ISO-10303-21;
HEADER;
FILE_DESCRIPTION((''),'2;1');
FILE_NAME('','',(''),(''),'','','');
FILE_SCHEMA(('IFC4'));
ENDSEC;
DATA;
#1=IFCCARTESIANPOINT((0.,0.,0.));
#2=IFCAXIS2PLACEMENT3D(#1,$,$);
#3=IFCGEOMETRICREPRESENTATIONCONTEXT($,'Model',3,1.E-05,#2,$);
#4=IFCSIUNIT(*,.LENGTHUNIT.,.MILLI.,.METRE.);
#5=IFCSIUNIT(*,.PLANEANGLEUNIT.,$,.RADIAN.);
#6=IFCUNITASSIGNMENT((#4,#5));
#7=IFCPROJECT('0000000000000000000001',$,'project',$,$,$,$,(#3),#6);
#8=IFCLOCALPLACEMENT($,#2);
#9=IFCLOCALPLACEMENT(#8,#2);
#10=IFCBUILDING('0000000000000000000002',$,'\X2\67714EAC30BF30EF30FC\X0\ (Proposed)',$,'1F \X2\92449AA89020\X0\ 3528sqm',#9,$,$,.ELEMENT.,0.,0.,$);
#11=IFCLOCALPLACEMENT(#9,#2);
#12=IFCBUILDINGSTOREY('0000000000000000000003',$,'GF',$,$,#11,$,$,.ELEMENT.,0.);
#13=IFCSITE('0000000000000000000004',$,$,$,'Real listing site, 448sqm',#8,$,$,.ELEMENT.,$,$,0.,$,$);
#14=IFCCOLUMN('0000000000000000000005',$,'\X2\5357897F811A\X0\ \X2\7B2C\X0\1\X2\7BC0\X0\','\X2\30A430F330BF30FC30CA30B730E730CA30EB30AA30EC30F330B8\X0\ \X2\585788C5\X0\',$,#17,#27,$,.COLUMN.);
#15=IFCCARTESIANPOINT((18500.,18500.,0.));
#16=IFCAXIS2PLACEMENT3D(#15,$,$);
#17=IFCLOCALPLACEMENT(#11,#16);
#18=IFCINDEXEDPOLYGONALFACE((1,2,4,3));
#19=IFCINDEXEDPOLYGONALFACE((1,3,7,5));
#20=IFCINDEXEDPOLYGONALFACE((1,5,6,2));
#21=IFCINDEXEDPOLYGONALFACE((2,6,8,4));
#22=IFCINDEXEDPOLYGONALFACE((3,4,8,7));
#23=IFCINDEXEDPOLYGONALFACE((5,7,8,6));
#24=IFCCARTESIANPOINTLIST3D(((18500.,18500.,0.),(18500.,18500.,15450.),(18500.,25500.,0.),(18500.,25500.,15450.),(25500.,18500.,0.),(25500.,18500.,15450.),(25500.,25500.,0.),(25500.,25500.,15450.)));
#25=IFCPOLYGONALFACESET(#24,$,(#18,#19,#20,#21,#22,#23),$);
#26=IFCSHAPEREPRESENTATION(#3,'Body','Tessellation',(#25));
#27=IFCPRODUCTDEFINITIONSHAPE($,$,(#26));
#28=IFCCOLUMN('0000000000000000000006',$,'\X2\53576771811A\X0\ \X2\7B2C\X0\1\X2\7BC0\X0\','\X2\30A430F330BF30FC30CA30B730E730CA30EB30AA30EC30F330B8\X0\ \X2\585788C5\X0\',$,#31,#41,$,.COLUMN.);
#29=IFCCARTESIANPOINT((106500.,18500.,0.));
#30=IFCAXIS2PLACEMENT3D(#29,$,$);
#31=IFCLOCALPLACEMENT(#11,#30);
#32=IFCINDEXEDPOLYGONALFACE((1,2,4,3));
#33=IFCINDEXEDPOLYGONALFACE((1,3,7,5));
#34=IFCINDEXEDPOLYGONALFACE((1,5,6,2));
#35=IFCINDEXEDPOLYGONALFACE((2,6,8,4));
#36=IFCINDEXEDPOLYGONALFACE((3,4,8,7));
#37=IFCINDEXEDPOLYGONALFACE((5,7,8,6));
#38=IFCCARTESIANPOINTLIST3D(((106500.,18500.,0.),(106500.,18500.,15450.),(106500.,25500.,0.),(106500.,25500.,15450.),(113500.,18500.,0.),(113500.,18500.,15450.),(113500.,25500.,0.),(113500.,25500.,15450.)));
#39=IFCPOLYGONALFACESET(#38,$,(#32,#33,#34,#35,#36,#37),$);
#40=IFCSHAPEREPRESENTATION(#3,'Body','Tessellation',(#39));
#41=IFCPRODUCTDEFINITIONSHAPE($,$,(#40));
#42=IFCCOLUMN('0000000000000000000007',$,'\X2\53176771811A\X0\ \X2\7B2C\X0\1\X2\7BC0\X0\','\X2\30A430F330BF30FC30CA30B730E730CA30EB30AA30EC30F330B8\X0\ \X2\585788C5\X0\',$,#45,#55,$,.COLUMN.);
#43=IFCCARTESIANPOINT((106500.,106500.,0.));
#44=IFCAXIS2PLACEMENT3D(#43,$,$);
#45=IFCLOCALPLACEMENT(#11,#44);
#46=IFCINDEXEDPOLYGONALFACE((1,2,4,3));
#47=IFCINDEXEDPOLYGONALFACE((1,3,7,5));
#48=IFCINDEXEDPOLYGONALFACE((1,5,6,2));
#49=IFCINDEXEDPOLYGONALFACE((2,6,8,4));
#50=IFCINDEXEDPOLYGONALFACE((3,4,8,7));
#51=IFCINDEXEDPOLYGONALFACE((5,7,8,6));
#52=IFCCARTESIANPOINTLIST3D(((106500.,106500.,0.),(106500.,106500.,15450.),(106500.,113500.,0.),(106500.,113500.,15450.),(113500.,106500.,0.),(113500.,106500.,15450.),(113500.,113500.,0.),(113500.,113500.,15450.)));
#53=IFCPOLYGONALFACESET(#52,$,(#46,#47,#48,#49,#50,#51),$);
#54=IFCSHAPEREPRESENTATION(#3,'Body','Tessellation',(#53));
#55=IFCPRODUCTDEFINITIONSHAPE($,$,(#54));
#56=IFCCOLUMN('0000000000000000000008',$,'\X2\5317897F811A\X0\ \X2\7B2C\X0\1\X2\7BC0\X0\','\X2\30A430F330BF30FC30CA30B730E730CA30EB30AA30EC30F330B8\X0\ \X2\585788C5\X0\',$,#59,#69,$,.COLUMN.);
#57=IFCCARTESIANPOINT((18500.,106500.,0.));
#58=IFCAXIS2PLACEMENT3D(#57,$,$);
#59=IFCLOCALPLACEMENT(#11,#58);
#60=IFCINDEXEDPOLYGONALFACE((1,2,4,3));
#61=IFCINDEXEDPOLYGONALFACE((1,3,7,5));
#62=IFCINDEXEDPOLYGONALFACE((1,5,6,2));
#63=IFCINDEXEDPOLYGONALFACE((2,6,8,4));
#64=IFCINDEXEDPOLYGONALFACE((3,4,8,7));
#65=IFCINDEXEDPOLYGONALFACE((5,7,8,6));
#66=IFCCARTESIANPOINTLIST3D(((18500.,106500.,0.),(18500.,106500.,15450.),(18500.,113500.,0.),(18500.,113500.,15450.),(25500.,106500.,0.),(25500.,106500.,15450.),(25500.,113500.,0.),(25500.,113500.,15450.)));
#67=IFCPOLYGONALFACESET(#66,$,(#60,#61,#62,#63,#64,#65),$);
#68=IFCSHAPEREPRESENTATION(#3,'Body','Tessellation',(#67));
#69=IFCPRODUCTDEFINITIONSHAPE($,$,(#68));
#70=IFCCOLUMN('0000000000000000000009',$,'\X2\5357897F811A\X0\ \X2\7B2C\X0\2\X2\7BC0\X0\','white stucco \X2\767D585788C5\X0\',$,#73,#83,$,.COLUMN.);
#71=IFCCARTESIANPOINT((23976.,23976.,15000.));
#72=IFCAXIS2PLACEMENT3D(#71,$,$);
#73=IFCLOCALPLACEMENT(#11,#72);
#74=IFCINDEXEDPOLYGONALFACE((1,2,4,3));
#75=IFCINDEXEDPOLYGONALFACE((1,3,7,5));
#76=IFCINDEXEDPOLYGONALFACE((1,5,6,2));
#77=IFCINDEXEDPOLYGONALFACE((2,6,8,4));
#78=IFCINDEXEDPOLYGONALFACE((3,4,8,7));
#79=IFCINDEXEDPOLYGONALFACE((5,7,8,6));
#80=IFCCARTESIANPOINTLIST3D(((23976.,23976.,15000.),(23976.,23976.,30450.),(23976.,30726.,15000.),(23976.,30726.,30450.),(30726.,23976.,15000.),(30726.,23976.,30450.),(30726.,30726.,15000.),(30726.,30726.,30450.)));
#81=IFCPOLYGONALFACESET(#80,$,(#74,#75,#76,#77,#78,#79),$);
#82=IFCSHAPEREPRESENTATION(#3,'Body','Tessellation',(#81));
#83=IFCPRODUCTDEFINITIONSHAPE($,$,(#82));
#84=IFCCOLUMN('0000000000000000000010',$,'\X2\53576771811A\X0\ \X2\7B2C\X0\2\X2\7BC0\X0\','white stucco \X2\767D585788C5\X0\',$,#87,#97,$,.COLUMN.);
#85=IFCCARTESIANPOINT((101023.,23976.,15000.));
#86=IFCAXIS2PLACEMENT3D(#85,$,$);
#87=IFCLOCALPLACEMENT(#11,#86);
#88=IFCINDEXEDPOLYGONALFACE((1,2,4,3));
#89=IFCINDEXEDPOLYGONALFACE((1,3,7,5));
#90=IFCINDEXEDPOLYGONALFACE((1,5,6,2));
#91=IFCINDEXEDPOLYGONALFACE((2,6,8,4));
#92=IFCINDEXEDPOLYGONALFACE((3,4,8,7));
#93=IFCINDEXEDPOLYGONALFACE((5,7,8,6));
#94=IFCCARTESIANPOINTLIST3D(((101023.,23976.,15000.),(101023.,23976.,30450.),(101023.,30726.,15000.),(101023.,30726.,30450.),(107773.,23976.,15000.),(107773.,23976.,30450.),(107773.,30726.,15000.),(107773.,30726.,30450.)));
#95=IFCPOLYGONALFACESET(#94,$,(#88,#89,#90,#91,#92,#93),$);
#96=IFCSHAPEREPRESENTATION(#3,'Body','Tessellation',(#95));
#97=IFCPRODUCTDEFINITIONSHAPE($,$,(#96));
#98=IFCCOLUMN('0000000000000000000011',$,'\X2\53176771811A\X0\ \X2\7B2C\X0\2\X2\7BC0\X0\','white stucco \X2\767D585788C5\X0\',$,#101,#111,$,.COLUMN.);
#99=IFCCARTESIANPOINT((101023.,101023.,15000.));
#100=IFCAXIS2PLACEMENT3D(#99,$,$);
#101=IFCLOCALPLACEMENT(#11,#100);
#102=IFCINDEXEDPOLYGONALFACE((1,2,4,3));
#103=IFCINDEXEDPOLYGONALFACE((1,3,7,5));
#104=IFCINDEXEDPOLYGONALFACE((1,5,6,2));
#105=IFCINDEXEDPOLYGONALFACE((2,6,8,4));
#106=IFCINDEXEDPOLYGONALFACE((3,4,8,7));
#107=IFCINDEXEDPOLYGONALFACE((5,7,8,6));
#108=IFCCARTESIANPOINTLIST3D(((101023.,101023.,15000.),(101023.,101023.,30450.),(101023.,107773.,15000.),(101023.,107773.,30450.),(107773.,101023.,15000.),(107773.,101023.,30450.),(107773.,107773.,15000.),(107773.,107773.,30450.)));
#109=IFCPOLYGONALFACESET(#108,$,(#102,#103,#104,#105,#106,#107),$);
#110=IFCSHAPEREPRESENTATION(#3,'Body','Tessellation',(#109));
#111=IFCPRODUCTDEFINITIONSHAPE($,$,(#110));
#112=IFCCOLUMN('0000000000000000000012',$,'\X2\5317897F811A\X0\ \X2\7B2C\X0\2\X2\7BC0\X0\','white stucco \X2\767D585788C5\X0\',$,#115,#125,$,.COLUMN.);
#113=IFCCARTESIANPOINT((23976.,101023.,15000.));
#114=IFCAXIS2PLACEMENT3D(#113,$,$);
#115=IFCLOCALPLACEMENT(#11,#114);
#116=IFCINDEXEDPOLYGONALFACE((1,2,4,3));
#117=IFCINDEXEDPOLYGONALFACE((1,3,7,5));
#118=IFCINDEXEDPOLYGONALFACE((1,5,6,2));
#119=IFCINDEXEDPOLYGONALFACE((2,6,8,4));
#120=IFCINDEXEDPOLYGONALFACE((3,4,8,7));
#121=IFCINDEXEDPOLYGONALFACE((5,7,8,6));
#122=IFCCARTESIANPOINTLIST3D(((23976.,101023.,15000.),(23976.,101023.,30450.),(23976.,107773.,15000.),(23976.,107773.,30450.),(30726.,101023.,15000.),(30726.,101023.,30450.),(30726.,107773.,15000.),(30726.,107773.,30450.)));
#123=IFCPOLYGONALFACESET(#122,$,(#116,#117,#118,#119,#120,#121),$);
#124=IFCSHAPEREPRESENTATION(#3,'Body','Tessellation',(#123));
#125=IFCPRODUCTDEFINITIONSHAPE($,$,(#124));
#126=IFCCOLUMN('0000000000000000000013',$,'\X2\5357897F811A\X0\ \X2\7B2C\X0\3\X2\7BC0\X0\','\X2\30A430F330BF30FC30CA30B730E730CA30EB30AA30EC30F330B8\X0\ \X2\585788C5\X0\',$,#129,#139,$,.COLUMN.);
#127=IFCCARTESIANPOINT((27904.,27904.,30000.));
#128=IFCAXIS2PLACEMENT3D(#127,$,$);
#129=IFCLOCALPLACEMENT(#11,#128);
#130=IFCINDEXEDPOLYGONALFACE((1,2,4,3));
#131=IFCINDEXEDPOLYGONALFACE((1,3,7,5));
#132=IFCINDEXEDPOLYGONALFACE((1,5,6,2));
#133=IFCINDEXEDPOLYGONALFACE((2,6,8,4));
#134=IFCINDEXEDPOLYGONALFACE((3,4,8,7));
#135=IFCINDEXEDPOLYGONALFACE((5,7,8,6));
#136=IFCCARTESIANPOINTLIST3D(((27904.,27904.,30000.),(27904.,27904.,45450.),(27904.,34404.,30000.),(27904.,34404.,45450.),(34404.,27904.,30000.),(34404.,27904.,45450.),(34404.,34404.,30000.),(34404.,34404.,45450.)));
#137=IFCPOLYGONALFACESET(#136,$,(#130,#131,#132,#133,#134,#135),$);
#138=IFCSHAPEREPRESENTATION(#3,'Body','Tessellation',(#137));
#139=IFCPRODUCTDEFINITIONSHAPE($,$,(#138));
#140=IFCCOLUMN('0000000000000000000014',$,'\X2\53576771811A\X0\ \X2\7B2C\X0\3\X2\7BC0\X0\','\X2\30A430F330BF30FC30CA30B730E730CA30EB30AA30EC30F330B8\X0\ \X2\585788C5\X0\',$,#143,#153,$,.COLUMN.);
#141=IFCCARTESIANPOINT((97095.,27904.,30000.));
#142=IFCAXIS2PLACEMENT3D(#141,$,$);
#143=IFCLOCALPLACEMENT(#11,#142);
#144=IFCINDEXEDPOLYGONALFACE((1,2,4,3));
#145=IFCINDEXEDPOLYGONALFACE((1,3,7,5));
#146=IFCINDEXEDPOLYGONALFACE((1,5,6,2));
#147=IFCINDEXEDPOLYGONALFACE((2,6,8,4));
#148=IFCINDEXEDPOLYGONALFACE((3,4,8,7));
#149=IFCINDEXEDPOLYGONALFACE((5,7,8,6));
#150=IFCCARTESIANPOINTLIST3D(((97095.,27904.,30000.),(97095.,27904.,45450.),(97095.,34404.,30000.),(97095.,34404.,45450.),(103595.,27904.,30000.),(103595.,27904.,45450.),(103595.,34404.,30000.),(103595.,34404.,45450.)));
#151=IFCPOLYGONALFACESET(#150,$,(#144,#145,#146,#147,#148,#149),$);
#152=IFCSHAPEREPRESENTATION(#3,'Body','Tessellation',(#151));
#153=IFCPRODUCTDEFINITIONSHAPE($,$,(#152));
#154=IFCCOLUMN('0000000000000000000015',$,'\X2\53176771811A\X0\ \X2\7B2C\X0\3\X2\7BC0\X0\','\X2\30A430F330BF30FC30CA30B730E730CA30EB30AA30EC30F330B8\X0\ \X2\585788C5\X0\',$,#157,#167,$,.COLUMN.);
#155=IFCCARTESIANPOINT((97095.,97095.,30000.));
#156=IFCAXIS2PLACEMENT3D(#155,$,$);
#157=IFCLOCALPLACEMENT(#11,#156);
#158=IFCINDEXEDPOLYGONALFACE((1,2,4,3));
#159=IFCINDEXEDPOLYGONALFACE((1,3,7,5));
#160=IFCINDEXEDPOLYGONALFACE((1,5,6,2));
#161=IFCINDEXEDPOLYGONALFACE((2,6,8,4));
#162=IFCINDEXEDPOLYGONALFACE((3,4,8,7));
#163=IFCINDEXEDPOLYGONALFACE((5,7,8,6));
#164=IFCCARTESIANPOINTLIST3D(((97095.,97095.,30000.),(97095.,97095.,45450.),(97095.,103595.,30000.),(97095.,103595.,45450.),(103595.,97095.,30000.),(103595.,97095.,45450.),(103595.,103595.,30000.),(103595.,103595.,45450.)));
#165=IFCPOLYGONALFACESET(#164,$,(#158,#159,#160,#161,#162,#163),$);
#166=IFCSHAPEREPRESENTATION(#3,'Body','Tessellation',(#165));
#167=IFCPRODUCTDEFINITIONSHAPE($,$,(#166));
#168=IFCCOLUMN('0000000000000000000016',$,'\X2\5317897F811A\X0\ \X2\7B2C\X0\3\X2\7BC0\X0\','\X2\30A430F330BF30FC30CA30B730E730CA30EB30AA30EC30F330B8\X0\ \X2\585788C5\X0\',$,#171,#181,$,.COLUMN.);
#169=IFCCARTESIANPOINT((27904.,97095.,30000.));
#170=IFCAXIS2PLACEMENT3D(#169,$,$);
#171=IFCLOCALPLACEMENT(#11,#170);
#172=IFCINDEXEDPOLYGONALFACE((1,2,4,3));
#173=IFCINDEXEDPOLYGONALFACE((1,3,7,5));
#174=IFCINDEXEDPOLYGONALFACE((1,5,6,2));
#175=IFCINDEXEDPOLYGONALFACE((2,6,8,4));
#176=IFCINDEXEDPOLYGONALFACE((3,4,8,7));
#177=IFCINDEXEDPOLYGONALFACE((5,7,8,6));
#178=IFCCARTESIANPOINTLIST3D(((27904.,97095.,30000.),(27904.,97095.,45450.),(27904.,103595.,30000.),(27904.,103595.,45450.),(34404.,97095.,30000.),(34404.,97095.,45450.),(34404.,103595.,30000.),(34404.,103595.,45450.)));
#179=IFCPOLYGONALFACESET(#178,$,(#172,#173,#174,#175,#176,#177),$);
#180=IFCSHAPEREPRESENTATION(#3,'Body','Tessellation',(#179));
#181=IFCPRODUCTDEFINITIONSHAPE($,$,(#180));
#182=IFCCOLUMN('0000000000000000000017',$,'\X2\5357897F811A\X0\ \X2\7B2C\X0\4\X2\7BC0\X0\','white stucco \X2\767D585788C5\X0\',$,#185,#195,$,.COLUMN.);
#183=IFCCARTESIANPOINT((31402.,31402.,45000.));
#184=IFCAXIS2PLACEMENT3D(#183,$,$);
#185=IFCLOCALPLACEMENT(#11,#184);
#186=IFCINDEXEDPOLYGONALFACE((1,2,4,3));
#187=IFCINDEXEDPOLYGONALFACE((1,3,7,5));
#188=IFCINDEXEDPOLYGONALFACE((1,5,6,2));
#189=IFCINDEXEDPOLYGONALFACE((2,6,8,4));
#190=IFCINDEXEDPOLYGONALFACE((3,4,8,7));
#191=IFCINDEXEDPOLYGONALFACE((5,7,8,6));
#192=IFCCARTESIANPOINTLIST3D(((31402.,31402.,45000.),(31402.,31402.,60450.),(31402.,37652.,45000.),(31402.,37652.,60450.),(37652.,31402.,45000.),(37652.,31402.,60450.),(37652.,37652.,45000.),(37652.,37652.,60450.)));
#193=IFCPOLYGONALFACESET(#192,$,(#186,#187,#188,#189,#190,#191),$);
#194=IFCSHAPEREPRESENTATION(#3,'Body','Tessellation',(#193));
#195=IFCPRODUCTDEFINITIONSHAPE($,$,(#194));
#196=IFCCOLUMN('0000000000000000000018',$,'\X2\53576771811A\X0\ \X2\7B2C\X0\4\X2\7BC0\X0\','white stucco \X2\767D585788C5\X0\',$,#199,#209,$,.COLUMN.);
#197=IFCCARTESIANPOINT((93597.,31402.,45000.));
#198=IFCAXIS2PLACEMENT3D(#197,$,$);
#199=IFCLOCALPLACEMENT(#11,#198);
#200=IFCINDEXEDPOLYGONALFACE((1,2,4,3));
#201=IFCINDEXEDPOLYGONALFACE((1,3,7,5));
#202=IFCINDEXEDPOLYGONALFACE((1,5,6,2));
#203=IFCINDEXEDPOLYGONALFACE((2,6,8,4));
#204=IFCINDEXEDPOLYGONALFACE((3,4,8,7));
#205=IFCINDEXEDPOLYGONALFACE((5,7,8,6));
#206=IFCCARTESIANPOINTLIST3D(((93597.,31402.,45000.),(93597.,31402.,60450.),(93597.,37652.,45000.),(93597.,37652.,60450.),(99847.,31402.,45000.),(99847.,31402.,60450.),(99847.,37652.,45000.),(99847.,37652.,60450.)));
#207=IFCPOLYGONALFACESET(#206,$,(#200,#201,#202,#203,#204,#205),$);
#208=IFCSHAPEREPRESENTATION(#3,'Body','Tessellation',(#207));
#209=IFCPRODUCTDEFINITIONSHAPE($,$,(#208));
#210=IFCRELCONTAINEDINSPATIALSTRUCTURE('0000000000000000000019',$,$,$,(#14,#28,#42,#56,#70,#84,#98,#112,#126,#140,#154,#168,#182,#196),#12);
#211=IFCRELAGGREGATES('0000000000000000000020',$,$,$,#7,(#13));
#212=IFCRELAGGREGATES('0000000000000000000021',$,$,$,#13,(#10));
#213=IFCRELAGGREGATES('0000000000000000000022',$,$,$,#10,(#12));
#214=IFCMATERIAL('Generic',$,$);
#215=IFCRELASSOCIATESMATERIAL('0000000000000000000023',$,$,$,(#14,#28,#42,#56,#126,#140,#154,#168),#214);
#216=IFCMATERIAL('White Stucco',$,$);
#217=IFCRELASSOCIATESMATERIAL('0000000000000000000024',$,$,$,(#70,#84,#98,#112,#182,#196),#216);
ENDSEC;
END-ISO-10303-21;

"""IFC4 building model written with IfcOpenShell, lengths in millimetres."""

from ifc_helpers import new_model, si_unit, frame, frame_2d, origin, place, context, project, spatial, rectangle, extrude, material, element, save


model = new_model("IFC4")

# Units and contexts
model_context = context("Model", 3, precision=1e-05, world=origin())
ifc_project = project(units=[si_unit("LENGTHUNIT", "METRE", prefix="MILLI"), si_unit("PLANEANGLEUNIT", "RADIAN")], contexts=[model_context])

# Site, building, storey
site_placement = place(None, origin())
site = spatial("IfcSite", under=ifc_project, at=site_placement, ObjectType="Real listing site, 448sqm", CompositionType="ELEMENT", RefElevation=0.0)
building_placement = place(site_placement, origin())
building = spatial("IfcBuilding", under=site, at=building_placement, Name="東京タワー (Proposed)", ObjectType="1F 鉄骨造 3528sqm", CompositionType="ELEMENT", ElevationOfRefHeight=0.0, ElevationOfTerrain=0.0)
storey_placement = place(building_placement, origin())
storey = spatial("IfcBuildingStorey", under=building, at=storey_placement, Name="GF", CompositionType="ELEMENT", Elevation=0.0)

# Columns
ifc_material_1 = material(Name="Generic")
column_1_placement = place(storey_placement, frame((18500.0, 18500.0, 0.0)))
element("IfcColumn", 1, at=column_1_placement, inside=storey, material=ifc_material_1, Name="南西脚 第1節", Description="インターナショナルオレンジ 塗装", PredefinedType="COLUMN", context=model_context, shape_type="SweptSolid", body=[
    extrude(rectangle(XDim=7000.0, YDim=7000.0, at=frame_2d((3500.0, 3500.0))), frame((18500.0, 18500.0, 0.0)), (0.0, 0.0, 1.0), 15450.0),
])
column_2_placement = place(storey_placement, frame((106500.0, 18500.0, 0.0)))
element("IfcColumn", 2, at=column_2_placement, inside=storey, material=ifc_material_1, Name="南東脚 第1節", Description="インターナショナルオレンジ 塗装", PredefinedType="COLUMN", context=model_context, shape_type="SweptSolid", body=[
    extrude(rectangle(XDim=7000.0, YDim=7000.0, at=frame_2d((3500.0, 3500.0))), frame((106500.0, 18500.0, 0.0)), (0.0, 0.0, 1.0), 15450.0),
])
column_3_placement = place(storey_placement, frame((106500.0, 106500.0, 0.0)))
element("IfcColumn", 3, at=column_3_placement, inside=storey, material=ifc_material_1, Name="北東脚 第1節", Description="インターナショナルオレンジ 塗装", PredefinedType="COLUMN", context=model_context, shape_type="SweptSolid", body=[
    extrude(rectangle(XDim=7000.0, YDim=7000.0, at=frame_2d((3500.0, 3500.0))), frame((106500.0, 106500.0, 0.0)), (0.0, 0.0, 1.0), 15450.0),
])
column_4_placement = place(storey_placement, frame((18500.0, 106500.0, 0.0)))
element("IfcColumn", 4, at=column_4_placement, inside=storey, material=ifc_material_1, Name="北西脚 第1節", Description="インターナショナルオレンジ 塗装", PredefinedType="COLUMN", context=model_context, shape_type="SweptSolid", body=[
    extrude(rectangle(XDim=7000.0, YDim=7000.0, at=frame_2d((3500.0, 3500.0))), frame((18500.0, 106500.0, 0.0)), (0.0, 0.0, 1.0), 15450.0),
])
ifc_material_2 = material(Name="White Stucco")
column_5_placement = place(storey_placement, frame((23976.0, 23976.0, 15000.0)))
element("IfcColumn", 5, at=column_5_placement, inside=storey, material=ifc_material_2, Name="南西脚 第2節", Description="white stucco 白塗装", PredefinedType="COLUMN", context=model_context, shape_type="SweptSolid", body=[
    extrude(rectangle(XDim=6750.0, YDim=6750.0, at=frame_2d((3375.0, 3375.0))), frame((23976.0, 23976.0, 15000.0)), (0.0, 0.0, 1.0), 15450.0),
])
column_6_placement = place(storey_placement, frame((101023.0, 23976.0, 15000.0)))
element("IfcColumn", 6, at=column_6_placement, inside=storey, material=ifc_material_2, Name="南東脚 第2節", Description="white stucco 白塗装", PredefinedType="COLUMN", context=model_context, shape_type="SweptSolid", body=[
    extrude(rectangle(XDim=6750.0, YDim=6750.0, at=frame_2d((3375.0, 3375.0))), frame((101023.0, 23976.0, 15000.0)), (0.0, 0.0, 1.0), 15450.0),
])
column_7_placement = place(storey_placement, frame((101023.0, 101023.0, 15000.0)))
element("IfcColumn", 7, at=column_7_placement, inside=storey, material=ifc_material_2, Name="北東脚 第2節", Description="white stucco 白塗装", PredefinedType="COLUMN", context=model_context, shape_type="SweptSolid", body=[
    extrude(rectangle(XDim=6750.0, YDim=6750.0, at=frame_2d((3375.0, 3375.0))), frame((101023.0, 101023.0, 15000.0)), (0.0, 0.0, 1.0), 15450.0),
])
column_8_placement = place(storey_placement, frame((23976.0, 101023.0, 15000.0)))
element("IfcColumn", 8, at=column_8_placement, inside=storey, material=ifc_material_2, Name="北西脚 第2節", Description="white stucco 白塗装", PredefinedType="COLUMN", context=model_context, shape_type="SweptSolid", body=[
    extrude(rectangle(XDim=6750.0, YDim=6750.0, at=frame_2d((3375.0, 3375.0))), frame((23976.0, 101023.0, 15000.0)), (0.0, 0.0, 1.0), 15450.0),
])
column_9_placement = place(storey_placement, frame((27904.0, 27904.0, 30000.0)))
element("IfcColumn", 9, at=column_9_placement, inside=storey, material=ifc_material_1, Name="南西脚 第3節", Description="インターナショナルオレンジ 塗装", PredefinedType="COLUMN", context=model_context, shape_type="SweptSolid", body=[
    extrude(rectangle(XDim=6500.0, YDim=6500.0, at=frame_2d((3250.0, 3250.0))), frame((27904.0, 27904.0, 30000.0)), (0.0, 0.0, 1.0), 15450.0),
])
column_10_placement = place(storey_placement, frame((97095.0, 27904.0, 30000.0)))
element("IfcColumn", 10, at=column_10_placement, inside=storey, material=ifc_material_1, Name="南東脚 第3節", Description="インターナショナルオレンジ 塗装", PredefinedType="COLUMN", context=model_context, shape_type="SweptSolid", body=[
    extrude(rectangle(XDim=6500.0, YDim=6500.0, at=frame_2d((3250.0, 3250.0))), frame((97095.0, 27904.0, 30000.0)), (0.0, 0.0, 1.0), 15450.0),
])
column_11_placement = place(storey_placement, frame((97095.0, 97095.0, 30000.0)))
element("IfcColumn", 11, at=column_11_placement, inside=storey, material=ifc_material_1, Name="北東脚 第3節", Description="インターナショナルオレンジ 塗装", PredefinedType="COLUMN", context=model_context, shape_type="SweptSolid", body=[
    extrude(rectangle(XDim=6500.0, YDim=6500.0, at=frame_2d((3250.0, 3250.0))), frame((97095.0, 97095.0, 30000.0)), (0.0, 0.0, 1.0), 15450.0),
])
column_12_placement = place(storey_placement, frame((27904.0, 97095.0, 30000.0)))
element("IfcColumn", 12, at=column_12_placement, inside=storey, material=ifc_material_1, Name="北西脚 第3節", Description="インターナショナルオレンジ 塗装", PredefinedType="COLUMN", context=model_context, shape_type="SweptSolid", body=[
    extrude(rectangle(XDim=6500.0, YDim=6500.0, at=frame_2d((3250.0, 3250.0))), frame((27904.0, 97095.0, 30000.0)), (0.0, 0.0, 1.0), 15450.0),
])
column_13_placement = place(storey_placement, frame((31402.0, 31402.0, 45000.0)))
element("IfcColumn", 13, at=column_13_placement, inside=storey, material=ifc_material_2, Name="南西脚 第4節", Description="white stucco 白塗装", PredefinedType="COLUMN", context=model_context, shape_type="SweptSolid", body=[
    extrude(rectangle(XDim=6250.0, YDim=6250.0, at=frame_2d((3125.0, 3125.0))), frame((31402.0, 31402.0, 45000.0)), (0.0, 0.0, 1.0), 15450.0),
])
column_14_placement = place(storey_placement, frame((93597.0, 31402.0, 45000.0)))
element("IfcColumn", 14, at=column_14_placement, inside=storey, material=ifc_material_2, Name="南東脚 第4節", Description="white stucco 白塗装", PredefinedType="COLUMN", context=model_context, shape_type="SweptSolid", body=[
    extrude(rectangle(XDim=6250.0, YDim=6250.0, at=frame_2d((3125.0, 3125.0))), frame((93597.0, 31402.0, 45000.0)), (0.0, 0.0, 1.0), 15450.0),
])

save(model, "model.ifc")
